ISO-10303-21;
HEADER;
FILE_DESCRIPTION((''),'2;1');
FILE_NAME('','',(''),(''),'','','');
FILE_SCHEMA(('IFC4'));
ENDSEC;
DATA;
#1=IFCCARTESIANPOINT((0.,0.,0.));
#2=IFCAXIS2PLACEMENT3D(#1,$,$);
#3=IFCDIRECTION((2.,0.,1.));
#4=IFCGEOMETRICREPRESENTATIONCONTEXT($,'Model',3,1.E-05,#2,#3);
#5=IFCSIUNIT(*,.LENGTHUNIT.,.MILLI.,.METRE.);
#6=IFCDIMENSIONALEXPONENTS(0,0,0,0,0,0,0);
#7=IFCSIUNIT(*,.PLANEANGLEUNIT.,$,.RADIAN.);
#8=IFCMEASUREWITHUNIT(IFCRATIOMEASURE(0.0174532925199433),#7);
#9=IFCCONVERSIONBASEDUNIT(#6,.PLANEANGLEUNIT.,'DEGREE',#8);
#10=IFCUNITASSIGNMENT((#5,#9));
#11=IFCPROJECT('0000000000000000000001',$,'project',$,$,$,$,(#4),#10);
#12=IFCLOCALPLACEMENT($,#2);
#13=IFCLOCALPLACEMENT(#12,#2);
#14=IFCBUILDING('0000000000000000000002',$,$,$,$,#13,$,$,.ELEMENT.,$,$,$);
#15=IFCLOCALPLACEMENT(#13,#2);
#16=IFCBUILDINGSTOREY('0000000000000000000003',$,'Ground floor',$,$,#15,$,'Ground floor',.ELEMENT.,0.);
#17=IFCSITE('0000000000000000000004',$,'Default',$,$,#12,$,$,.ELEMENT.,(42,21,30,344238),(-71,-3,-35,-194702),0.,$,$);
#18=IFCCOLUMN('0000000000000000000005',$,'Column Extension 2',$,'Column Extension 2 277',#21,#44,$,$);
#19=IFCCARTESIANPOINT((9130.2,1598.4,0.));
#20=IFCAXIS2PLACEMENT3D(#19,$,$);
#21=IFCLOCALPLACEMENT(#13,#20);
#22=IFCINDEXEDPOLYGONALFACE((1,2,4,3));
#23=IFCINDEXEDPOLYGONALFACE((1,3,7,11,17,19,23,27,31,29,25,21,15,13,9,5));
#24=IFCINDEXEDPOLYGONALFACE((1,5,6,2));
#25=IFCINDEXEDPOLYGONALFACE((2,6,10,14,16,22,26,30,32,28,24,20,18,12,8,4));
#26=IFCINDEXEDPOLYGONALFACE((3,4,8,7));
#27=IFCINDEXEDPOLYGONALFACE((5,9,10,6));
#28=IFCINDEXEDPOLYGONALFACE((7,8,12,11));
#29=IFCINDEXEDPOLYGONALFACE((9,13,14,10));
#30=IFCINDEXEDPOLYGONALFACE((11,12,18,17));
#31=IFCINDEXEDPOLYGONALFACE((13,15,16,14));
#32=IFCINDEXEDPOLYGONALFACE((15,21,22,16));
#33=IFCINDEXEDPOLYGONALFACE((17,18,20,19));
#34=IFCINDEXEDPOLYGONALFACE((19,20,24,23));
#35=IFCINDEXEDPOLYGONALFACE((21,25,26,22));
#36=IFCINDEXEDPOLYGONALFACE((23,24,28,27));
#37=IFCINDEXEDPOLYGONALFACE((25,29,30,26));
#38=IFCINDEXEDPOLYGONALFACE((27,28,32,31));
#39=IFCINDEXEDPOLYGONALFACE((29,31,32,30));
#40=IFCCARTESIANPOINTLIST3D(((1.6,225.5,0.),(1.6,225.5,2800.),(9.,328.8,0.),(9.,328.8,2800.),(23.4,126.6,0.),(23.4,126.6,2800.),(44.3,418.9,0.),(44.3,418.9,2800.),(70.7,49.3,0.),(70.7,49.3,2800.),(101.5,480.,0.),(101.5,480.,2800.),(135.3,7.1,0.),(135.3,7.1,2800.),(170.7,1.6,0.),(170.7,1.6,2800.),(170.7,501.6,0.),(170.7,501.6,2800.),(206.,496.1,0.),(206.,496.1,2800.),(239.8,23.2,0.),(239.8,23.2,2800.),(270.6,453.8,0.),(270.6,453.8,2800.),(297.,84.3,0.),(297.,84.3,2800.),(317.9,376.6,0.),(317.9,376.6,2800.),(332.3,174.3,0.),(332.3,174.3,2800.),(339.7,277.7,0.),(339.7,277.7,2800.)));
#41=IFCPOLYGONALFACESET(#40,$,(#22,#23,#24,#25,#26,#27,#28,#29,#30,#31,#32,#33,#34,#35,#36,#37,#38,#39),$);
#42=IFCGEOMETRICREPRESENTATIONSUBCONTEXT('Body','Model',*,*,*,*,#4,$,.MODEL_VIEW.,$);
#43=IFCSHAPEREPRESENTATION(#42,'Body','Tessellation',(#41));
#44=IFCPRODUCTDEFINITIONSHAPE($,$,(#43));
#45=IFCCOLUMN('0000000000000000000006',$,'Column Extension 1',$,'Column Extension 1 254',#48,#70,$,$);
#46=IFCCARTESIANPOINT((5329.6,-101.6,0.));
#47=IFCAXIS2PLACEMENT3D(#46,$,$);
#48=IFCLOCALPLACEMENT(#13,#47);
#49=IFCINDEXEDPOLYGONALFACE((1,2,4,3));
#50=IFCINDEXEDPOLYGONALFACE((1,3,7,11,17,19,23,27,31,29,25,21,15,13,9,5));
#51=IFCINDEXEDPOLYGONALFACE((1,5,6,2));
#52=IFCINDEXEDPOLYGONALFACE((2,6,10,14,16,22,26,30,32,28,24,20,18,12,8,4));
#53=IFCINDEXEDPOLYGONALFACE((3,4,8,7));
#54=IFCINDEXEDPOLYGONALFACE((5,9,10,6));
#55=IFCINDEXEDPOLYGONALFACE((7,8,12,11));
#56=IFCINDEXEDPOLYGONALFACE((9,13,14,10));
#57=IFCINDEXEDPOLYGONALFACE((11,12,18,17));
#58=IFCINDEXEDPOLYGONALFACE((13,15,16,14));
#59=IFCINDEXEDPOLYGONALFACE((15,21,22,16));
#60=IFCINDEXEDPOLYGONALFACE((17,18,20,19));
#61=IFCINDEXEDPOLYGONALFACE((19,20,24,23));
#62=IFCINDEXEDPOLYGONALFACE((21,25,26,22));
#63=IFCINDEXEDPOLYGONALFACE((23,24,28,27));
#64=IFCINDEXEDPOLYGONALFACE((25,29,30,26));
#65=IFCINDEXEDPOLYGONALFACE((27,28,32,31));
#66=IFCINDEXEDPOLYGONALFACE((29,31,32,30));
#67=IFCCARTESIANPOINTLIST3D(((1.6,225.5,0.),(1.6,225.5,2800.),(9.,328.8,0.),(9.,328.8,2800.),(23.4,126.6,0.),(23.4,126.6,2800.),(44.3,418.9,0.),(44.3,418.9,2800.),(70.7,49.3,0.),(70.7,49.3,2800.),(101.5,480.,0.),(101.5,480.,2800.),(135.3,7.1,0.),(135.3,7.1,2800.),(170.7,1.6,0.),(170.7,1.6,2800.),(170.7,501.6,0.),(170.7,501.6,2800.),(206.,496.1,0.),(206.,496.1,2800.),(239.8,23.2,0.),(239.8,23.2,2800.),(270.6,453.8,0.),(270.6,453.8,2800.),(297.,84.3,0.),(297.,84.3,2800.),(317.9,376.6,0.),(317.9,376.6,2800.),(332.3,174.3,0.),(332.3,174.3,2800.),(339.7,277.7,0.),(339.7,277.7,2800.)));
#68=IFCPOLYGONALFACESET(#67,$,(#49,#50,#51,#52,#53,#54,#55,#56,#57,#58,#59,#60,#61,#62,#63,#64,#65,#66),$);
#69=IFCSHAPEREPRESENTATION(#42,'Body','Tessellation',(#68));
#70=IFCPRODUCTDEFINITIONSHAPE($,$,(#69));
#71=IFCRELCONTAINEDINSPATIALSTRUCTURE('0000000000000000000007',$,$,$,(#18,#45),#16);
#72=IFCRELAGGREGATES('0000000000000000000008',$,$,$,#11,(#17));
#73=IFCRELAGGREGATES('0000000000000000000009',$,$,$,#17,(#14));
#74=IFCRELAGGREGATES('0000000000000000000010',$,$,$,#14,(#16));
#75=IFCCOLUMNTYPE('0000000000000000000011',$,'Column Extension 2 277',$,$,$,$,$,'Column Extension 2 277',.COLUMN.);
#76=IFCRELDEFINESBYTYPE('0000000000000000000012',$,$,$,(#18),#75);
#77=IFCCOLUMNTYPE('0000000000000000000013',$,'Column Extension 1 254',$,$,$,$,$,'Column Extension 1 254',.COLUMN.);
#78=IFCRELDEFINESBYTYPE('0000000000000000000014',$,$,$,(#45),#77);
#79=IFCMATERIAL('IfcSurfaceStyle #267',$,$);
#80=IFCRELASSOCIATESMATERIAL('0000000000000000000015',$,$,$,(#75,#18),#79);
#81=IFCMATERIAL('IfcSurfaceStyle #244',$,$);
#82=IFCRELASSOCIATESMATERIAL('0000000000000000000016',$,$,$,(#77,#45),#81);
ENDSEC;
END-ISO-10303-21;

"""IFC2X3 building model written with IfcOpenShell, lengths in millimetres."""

from ifc_helpers import new_model, entity, si_unit, converted_unit, direction, frame, origin, place, context, subcontext, project, spatial, polyline, outline, extrude, source, transform, mapped, material, type_object, type_shapes, element, save


model = new_model("IFC2X3")

# Units and contexts
model_context = context("Model", 3, precision=1e-05, world=origin(), true_north=direction((2.0, 0.0, 1.0)))
body_context = subcontext(model_context, "Body", "Model", "MODEL_VIEW")
ifc_project = project(units=[si_unit("LENGTHUNIT", "METRE", prefix="MILLI"), converted_unit("PLANEANGLEUNIT", "DEGREE", entity("IfcRatioMeasure", 0.0174532925199433), si_unit("PLANEANGLEUNIT", "RADIAN"), dimensions=[0, 0, 0, 0, 0, 0, 0])], contexts=[model_context])

# Site, building, storey
site_placement = place(None, origin())
site = spatial("IfcSite", under=ifc_project, at=site_placement, Name="Default", CompositionType="ELEMENT", RefLatitude=(42, 21, 30, 344238), RefLongitude=(-71, -3, -35, -194702), RefElevation=0.0)
building_placement = place(site_placement, origin())
building = spatial("IfcBuilding", under=site, at=building_placement, CompositionType="ELEMENT")
storey_placement = place(building_placement, origin())
storey = spatial("IfcBuildingStorey", under=building, at=storey_placement, Name="Ground floor", LongName="Ground floor", CompositionType="ELEMENT", Elevation=0.0)

# Columns
ifc_material_1 = material(Name="IfcSurfaceStyle #267")
column_type_1 = type_object("IfcColumnType", Name="Column Extension 2 277", ElementType="Column Extension 2 277", PredefinedType="COLUMN", material=ifc_material_1)
shared_shape_1 = source(origin(), body_context, "Body", "SweptSolid", [
    extrude(outline(polyline([(-74.6, -238.6), (-2.1, -238.6), (70.7, -197.4), (131.3, -122.0), (169.2, -25.5), (177.8, 75.4), (155.7, 163.2), (106.7, 222.9), (74.6, 238.6), (2.1, 238.6), (-70.7, 197.4), (-131.3, 122.0), (-169.2, 25.5), (-177.8, -75.4), (-155.7, -163.2), (-106.7, -222.9), (-74.6, -238.6)])), frame((170.7, 251.6, 0.0), z_axis=(0.0, 0.0, 1.0), x_axis=(-0.954457, -0.298347, 0.0)), (0.0, 0.0, 1.0), 2800.0),
])
type_shapes(column_type_1, [shared_shape_1])
column_1_placement = place(building_placement, frame((9130.2, 1598.4, 0.0)))
element("IfcColumn", 1, at=column_1_placement, inside=storey, type_object=column_type_1, material=ifc_material_1, Name="Column Extension 2", ObjectType="Column Extension 2 277", context=body_context, shape_type="MappedRepresentation", body=[
    mapped(shared_shape_1, transform((0.0, 0.0, 0.0), scale=1.0)),
])
ifc_material_2 = material(Name="IfcSurfaceStyle #244")
column_type_2 = type_object("IfcColumnType", Name="Column Extension 1 254", ElementType="Column Extension 1 254", PredefinedType="COLUMN", material=ifc_material_2)
shared_shape_2 = source(origin(), body_context, "Body", "SweptSolid", [
    extrude(outline(polyline([(-74.6, -238.6), (-2.1, -238.6), (70.7, -197.4), (131.3, -122.0), (169.2, -25.5), (177.8, 75.4), (155.7, 163.2), (106.7, 222.9), (74.6, 238.6), (2.1, 238.6), (-70.7, 197.4), (-131.3, 122.0), (-169.2, 25.5), (-177.8, -75.4), (-155.7, -163.2), (-106.7, -222.9), (-74.6, -238.6)])), frame((170.7, 251.6, 0.0), z_axis=(0.0, 0.0, 1.0), x_axis=(-0.954457, -0.298347, 0.0)), (0.0, 0.0, 1.0), 2800.0),
])
type_shapes(column_type_2, [shared_shape_2])
column_2_placement = place(building_placement, frame((5329.6, -101.6, 0.0)))
element("IfcColumn", 2, at=column_2_placement, inside=storey, type_object=column_type_2, material=ifc_material_2, Name="Column Extension 1", ObjectType="Column Extension 1 254", context=body_context, shape_type="MappedRepresentation", body=[
    mapped(shared_shape_2, transform((0.0, 0.0, 0.0), scale=1.0)),
])

save(model, "model.ifc")
